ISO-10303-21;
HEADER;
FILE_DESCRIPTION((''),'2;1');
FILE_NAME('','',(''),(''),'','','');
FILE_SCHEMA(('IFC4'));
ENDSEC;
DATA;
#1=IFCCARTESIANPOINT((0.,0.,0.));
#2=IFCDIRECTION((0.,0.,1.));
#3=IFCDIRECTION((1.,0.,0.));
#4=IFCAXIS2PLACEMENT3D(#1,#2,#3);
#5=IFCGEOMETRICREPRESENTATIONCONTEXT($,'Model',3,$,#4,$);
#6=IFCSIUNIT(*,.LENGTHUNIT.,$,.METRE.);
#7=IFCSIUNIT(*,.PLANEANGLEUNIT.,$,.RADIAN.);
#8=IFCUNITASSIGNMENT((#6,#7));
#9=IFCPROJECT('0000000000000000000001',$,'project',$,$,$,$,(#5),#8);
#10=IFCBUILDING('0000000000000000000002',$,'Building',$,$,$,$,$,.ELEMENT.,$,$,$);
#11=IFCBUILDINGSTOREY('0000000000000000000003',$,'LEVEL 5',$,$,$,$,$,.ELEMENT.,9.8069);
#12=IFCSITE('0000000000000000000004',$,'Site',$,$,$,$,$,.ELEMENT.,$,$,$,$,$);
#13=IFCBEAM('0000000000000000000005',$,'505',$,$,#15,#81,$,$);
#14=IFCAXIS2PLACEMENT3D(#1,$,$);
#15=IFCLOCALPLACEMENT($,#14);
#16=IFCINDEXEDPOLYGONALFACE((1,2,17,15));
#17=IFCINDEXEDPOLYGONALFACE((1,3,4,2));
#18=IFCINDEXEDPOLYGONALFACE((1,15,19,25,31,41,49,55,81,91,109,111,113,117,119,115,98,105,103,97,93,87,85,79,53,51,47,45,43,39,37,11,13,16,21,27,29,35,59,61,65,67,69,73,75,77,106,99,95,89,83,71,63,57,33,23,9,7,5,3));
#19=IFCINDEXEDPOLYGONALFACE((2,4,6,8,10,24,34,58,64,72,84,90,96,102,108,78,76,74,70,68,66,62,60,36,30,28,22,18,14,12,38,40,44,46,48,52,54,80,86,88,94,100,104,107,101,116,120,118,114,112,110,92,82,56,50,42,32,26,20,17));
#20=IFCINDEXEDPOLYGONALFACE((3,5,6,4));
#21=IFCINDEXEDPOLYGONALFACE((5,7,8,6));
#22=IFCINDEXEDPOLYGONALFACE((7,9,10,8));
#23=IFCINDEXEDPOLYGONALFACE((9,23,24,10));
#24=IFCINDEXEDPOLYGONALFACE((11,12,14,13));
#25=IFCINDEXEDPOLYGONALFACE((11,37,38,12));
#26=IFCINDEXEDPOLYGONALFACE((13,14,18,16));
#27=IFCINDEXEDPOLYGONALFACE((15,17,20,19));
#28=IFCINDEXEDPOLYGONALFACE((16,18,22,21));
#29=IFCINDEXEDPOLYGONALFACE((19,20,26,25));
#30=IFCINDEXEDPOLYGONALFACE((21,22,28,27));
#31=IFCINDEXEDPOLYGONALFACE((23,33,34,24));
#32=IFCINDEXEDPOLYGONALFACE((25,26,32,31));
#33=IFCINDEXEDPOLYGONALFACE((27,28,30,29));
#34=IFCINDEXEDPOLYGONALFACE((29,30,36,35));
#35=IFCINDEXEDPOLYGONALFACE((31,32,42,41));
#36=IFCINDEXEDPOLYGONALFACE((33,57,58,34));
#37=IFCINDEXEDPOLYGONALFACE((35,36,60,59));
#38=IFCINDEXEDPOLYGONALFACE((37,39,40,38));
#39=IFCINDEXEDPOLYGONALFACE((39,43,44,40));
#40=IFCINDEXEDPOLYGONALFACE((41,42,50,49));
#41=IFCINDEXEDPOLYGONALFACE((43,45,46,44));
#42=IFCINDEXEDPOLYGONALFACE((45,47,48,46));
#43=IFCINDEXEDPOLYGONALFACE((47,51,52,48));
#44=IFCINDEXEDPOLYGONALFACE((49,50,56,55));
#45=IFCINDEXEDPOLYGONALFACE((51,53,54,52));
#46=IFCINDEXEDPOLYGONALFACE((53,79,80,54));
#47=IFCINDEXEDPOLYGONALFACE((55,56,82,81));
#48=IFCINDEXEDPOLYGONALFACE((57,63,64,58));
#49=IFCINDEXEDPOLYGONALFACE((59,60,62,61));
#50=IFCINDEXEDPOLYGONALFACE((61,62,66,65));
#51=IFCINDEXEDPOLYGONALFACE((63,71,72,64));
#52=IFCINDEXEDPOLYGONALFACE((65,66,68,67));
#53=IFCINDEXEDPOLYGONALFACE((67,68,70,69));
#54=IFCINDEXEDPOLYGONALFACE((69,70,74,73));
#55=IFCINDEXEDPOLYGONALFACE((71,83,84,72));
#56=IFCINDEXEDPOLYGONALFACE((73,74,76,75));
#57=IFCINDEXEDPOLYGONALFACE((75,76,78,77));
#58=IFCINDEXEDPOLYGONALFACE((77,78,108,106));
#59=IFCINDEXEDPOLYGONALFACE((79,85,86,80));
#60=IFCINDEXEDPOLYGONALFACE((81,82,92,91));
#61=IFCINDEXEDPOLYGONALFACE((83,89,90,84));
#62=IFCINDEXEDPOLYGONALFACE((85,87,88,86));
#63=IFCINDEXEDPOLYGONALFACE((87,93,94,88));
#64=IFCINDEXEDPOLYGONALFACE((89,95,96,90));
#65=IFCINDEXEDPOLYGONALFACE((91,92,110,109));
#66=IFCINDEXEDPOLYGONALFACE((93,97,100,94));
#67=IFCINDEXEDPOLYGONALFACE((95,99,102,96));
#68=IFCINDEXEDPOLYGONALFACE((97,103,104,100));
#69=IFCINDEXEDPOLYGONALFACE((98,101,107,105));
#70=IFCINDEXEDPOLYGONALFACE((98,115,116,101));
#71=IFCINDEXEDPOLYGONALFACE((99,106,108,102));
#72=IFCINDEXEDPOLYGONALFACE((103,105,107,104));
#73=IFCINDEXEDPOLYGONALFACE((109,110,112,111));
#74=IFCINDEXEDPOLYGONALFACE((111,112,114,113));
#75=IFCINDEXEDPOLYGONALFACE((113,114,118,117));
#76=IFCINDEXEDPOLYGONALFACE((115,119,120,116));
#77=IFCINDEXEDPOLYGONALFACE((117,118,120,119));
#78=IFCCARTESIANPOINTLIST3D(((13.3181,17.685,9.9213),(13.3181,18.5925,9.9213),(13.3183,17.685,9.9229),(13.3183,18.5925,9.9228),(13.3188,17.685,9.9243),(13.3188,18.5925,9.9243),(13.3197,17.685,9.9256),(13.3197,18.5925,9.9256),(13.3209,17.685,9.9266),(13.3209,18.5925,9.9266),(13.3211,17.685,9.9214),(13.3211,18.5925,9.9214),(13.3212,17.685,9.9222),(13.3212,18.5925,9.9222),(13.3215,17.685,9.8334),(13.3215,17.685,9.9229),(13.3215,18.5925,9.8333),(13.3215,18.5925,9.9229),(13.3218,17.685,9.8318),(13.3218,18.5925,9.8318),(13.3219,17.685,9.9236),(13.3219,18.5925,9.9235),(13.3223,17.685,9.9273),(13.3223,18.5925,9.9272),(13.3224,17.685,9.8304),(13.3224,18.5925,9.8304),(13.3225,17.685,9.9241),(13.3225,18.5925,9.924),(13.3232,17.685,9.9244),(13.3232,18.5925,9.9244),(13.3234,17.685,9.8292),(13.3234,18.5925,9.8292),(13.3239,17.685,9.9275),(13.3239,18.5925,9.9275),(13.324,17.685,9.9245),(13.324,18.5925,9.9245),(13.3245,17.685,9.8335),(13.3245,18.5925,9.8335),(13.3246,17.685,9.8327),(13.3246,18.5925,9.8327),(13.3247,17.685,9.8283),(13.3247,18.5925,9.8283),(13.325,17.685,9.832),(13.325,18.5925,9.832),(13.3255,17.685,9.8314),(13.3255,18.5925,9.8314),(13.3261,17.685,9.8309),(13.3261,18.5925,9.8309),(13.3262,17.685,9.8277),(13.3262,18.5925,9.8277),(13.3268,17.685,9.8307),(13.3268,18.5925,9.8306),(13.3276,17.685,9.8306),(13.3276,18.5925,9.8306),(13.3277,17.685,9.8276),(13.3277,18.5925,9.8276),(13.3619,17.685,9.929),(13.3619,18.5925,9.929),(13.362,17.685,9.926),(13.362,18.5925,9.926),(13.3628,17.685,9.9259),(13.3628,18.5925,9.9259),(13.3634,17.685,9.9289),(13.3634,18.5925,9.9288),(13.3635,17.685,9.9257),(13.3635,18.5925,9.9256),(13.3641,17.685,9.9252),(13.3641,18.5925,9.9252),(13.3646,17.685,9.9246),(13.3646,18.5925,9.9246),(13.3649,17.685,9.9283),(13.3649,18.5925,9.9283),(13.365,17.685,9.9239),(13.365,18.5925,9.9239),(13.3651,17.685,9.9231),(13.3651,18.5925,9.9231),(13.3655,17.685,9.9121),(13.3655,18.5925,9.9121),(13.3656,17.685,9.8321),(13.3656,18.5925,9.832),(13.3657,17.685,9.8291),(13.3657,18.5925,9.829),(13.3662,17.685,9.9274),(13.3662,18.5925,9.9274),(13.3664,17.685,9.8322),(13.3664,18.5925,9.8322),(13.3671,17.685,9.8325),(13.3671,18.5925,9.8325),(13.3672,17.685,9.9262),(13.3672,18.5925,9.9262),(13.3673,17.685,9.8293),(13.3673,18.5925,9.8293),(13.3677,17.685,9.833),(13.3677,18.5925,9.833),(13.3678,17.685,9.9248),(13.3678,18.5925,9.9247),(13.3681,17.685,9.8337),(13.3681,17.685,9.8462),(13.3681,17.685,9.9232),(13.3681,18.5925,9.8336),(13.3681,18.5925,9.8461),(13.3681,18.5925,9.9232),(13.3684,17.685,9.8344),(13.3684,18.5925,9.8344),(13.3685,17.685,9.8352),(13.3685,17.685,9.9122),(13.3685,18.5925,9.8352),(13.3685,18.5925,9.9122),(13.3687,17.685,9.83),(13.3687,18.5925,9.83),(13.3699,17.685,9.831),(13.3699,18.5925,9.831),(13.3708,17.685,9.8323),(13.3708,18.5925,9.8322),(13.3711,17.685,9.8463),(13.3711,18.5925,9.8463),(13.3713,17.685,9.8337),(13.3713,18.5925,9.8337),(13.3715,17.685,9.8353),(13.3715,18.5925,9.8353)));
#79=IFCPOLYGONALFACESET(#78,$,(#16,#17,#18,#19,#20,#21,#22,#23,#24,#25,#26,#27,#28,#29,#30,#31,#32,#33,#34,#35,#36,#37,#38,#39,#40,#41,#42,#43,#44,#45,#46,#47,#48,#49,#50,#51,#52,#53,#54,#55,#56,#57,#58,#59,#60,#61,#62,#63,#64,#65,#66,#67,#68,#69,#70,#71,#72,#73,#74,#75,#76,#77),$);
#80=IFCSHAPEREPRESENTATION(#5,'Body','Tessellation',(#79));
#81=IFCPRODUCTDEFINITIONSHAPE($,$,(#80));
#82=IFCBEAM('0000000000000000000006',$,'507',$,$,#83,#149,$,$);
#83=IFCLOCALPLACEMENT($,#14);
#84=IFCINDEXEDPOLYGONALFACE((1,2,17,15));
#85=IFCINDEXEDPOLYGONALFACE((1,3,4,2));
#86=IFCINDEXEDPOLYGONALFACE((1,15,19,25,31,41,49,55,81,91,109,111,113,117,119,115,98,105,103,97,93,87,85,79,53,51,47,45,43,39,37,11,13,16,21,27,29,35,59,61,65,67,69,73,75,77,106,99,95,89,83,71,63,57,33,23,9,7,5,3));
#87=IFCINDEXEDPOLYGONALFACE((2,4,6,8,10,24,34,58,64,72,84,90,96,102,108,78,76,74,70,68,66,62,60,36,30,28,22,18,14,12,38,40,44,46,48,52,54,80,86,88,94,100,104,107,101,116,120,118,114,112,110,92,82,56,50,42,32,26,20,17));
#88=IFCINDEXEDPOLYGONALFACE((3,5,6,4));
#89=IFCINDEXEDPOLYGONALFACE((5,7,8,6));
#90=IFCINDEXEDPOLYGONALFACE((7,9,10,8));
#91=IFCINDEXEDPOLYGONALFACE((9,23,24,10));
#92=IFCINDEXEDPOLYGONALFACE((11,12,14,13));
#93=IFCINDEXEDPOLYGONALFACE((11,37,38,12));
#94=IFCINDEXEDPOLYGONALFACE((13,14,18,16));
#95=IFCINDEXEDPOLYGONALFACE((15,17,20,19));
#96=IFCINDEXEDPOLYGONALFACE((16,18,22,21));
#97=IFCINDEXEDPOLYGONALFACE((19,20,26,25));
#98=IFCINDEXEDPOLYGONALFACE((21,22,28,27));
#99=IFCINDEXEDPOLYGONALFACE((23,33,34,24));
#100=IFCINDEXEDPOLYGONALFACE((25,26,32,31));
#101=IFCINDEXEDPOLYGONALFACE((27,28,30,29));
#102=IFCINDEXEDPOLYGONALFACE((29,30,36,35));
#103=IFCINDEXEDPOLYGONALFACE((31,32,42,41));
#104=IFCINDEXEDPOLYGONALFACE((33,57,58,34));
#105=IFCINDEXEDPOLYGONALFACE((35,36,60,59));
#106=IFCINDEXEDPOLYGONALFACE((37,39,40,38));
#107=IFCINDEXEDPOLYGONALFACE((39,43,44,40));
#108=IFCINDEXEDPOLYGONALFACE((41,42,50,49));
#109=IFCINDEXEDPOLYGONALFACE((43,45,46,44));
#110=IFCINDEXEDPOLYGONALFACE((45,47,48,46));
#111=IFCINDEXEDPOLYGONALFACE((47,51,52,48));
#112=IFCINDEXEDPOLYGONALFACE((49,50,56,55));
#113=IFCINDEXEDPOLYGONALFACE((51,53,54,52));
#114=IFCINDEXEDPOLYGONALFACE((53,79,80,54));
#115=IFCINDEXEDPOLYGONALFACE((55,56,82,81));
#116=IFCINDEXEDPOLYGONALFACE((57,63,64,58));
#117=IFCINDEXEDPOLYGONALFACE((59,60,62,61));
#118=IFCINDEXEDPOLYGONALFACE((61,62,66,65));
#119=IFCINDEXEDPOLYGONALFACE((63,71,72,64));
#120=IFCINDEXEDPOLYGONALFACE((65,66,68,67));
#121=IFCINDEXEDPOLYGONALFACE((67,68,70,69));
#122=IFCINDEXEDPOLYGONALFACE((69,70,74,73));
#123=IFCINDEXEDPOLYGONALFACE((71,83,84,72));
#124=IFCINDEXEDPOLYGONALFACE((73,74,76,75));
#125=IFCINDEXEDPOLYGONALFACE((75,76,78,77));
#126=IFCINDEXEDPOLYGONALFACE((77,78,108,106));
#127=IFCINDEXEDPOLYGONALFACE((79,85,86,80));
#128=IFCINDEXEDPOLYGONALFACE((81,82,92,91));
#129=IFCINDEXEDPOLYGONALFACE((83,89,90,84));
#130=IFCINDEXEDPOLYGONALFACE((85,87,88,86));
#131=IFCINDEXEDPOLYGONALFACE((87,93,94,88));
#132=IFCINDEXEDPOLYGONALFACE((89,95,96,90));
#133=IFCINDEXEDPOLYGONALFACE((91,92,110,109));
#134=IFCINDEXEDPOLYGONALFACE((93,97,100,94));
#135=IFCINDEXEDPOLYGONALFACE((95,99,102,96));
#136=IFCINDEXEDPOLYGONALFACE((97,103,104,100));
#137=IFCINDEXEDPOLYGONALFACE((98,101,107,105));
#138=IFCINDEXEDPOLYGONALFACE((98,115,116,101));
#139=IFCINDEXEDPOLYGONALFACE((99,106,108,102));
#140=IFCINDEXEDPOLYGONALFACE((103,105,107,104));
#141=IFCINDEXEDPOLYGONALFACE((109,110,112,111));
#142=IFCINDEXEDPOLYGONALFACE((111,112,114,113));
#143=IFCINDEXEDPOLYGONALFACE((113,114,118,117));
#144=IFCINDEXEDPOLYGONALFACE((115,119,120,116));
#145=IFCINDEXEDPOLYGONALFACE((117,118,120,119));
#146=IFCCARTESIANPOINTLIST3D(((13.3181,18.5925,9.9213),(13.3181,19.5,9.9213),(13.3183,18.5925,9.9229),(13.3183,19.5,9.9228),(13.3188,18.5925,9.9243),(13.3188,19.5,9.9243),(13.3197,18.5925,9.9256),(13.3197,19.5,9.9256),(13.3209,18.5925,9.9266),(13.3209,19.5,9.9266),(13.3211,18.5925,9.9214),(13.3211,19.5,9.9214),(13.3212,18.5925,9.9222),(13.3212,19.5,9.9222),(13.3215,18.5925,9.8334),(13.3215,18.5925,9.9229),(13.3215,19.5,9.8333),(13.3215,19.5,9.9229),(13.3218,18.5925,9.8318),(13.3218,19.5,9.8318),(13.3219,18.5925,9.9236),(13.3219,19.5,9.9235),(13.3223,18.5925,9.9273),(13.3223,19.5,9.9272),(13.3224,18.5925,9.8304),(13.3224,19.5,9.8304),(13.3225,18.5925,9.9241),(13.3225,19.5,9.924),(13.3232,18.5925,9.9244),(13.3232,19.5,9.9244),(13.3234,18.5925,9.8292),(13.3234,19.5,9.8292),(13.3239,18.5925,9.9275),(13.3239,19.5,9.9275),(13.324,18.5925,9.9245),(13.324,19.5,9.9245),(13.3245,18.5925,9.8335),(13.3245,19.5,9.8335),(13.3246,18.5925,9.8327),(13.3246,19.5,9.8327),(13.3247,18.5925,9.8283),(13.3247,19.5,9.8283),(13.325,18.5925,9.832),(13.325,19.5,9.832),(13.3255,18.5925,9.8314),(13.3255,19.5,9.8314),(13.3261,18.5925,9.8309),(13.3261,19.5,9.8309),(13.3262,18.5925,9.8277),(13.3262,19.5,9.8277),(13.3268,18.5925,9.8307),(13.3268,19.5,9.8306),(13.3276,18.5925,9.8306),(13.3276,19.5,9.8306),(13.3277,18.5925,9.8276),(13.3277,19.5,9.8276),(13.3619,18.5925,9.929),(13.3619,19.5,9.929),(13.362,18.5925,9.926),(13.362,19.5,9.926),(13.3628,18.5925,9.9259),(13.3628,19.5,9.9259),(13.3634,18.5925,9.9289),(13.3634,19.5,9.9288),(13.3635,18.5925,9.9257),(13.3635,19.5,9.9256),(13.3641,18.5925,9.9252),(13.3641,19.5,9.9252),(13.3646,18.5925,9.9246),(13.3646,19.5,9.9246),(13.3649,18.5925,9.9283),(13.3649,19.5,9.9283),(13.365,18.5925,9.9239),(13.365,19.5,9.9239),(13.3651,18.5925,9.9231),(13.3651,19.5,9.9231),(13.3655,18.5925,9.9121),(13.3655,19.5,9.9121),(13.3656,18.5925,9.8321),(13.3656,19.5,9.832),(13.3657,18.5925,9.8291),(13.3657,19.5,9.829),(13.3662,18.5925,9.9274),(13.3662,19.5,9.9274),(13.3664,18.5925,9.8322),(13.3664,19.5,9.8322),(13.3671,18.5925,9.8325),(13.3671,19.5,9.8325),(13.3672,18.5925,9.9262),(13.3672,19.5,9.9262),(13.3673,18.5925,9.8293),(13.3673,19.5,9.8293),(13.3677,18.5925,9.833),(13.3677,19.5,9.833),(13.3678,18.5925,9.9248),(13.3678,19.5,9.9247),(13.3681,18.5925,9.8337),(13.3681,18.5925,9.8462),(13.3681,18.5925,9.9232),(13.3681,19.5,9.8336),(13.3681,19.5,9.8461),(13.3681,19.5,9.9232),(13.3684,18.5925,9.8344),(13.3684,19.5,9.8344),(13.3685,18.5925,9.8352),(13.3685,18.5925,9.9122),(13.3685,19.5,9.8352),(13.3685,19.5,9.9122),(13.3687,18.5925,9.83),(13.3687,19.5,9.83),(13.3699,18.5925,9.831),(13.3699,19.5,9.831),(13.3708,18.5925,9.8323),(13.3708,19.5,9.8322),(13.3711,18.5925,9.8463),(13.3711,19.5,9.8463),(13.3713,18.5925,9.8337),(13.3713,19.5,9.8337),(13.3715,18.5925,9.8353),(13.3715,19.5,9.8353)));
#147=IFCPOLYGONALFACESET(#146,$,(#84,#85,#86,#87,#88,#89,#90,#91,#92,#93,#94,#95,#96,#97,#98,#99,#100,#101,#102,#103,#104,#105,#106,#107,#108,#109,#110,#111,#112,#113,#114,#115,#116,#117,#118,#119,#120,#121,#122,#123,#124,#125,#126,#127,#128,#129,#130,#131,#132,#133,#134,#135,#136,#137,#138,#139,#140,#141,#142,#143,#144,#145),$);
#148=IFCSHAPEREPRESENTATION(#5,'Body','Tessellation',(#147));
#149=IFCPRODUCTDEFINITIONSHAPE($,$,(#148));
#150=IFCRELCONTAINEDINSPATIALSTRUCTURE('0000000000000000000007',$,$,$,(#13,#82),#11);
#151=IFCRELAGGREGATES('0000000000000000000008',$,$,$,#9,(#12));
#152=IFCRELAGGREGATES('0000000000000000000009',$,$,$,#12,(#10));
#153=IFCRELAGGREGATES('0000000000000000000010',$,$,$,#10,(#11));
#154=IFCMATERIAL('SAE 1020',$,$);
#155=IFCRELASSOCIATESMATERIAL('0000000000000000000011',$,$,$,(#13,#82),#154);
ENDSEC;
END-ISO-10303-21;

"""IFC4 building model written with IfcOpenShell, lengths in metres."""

from ifc_helpers import new_model, si_unit, frame, origin_with_axes, origin_2d_with_axis, place, context, project, spatial, c_section, extrude, material, material_profile, profile_set, profile_usage, element, save


model = new_model("IFC4")

# Units and contexts
model_context = context("Model", 3, world=origin_with_axes())
ifc_project = project(units=[si_unit("LENGTHUNIT", "METRE"), si_unit("PLANEANGLEUNIT", "RADIAN")], contexts=[model_context])

# Site, building, storey
site = spatial("IfcSite", under=ifc_project, Name="Site", CompositionType="ELEMENT")
building = spatial("IfcBuilding", under=site, Name="Building", CompositionType="ELEMENT")
storey = spatial("IfcBuildingStorey", under=building, Name="LEVEL 5", CompositionType="ELEMENT", Elevation=9.8069)

# Beams
ifc_material = material(Name="SAE 1020")
ifc_material_profile_1 = material_profile(ifc_material, c_section(Depth=0.1, Width=0.05, WallThickness=0.003, Girth=0.017, InternalFilletRadius=0.003, at=origin_2d_with_axis()))
ifc_profile_set_1 = profile_set([ifc_material_profile_1])
ifc_profile_usage_1 = profile_usage(ifc_profile_set_1, cardinal=10)
beam_1_placement = place(None, frame((13.3448, 17.685, 9.8783), z_axis=(0.0, 1.0, -0.00003), x_axis=(0.999256, 0.000001, 0.038562)))
element("IfcBeam", 1, at=beam_1_placement, inside=storey, material=ifc_profile_usage_1, Name="505", context=model_context, shape_type="SweptSolid", body=[
    extrude(c_section(Depth=0.1, Width=0.05, WallThickness=0.003, Girth=0.017, InternalFilletRadius=0.003, at=origin_2d_with_axis()), origin_with_axes(), (0.0, 0.0, 1.0), 0.9075),
])
ifc_material_profile_2 = material_profile(ifc_material, c_section(Depth=0.1, Width=0.05, WallThickness=0.003, Girth=0.017, InternalFilletRadius=0.003, at=origin_2d_with_axis()))
ifc_profile_set_2 = profile_set([ifc_material_profile_2])
ifc_profile_usage_2 = profile_usage(ifc_profile_set_2, cardinal=10)
beam_2_placement = place(None, frame((13.3448, 18.5925, 9.8783), z_axis=(0.0, 1.0, -0.00003), x_axis=(0.999256, 0.000001, 0.038562)))
element("IfcBeam", 2, at=beam_2_placement, inside=storey, material=ifc_profile_usage_2, Name="507", context=model_context, shape_type="SweptSolid", body=[
    extrude(c_section(Depth=0.1, Width=0.05, WallThickness=0.003, Girth=0.017, InternalFilletRadius=0.003, at=origin_2d_with_axis()), origin_with_axes(), (0.0, 0.0, 1.0), 0.9075),
])

save(model, "model.ifc")
